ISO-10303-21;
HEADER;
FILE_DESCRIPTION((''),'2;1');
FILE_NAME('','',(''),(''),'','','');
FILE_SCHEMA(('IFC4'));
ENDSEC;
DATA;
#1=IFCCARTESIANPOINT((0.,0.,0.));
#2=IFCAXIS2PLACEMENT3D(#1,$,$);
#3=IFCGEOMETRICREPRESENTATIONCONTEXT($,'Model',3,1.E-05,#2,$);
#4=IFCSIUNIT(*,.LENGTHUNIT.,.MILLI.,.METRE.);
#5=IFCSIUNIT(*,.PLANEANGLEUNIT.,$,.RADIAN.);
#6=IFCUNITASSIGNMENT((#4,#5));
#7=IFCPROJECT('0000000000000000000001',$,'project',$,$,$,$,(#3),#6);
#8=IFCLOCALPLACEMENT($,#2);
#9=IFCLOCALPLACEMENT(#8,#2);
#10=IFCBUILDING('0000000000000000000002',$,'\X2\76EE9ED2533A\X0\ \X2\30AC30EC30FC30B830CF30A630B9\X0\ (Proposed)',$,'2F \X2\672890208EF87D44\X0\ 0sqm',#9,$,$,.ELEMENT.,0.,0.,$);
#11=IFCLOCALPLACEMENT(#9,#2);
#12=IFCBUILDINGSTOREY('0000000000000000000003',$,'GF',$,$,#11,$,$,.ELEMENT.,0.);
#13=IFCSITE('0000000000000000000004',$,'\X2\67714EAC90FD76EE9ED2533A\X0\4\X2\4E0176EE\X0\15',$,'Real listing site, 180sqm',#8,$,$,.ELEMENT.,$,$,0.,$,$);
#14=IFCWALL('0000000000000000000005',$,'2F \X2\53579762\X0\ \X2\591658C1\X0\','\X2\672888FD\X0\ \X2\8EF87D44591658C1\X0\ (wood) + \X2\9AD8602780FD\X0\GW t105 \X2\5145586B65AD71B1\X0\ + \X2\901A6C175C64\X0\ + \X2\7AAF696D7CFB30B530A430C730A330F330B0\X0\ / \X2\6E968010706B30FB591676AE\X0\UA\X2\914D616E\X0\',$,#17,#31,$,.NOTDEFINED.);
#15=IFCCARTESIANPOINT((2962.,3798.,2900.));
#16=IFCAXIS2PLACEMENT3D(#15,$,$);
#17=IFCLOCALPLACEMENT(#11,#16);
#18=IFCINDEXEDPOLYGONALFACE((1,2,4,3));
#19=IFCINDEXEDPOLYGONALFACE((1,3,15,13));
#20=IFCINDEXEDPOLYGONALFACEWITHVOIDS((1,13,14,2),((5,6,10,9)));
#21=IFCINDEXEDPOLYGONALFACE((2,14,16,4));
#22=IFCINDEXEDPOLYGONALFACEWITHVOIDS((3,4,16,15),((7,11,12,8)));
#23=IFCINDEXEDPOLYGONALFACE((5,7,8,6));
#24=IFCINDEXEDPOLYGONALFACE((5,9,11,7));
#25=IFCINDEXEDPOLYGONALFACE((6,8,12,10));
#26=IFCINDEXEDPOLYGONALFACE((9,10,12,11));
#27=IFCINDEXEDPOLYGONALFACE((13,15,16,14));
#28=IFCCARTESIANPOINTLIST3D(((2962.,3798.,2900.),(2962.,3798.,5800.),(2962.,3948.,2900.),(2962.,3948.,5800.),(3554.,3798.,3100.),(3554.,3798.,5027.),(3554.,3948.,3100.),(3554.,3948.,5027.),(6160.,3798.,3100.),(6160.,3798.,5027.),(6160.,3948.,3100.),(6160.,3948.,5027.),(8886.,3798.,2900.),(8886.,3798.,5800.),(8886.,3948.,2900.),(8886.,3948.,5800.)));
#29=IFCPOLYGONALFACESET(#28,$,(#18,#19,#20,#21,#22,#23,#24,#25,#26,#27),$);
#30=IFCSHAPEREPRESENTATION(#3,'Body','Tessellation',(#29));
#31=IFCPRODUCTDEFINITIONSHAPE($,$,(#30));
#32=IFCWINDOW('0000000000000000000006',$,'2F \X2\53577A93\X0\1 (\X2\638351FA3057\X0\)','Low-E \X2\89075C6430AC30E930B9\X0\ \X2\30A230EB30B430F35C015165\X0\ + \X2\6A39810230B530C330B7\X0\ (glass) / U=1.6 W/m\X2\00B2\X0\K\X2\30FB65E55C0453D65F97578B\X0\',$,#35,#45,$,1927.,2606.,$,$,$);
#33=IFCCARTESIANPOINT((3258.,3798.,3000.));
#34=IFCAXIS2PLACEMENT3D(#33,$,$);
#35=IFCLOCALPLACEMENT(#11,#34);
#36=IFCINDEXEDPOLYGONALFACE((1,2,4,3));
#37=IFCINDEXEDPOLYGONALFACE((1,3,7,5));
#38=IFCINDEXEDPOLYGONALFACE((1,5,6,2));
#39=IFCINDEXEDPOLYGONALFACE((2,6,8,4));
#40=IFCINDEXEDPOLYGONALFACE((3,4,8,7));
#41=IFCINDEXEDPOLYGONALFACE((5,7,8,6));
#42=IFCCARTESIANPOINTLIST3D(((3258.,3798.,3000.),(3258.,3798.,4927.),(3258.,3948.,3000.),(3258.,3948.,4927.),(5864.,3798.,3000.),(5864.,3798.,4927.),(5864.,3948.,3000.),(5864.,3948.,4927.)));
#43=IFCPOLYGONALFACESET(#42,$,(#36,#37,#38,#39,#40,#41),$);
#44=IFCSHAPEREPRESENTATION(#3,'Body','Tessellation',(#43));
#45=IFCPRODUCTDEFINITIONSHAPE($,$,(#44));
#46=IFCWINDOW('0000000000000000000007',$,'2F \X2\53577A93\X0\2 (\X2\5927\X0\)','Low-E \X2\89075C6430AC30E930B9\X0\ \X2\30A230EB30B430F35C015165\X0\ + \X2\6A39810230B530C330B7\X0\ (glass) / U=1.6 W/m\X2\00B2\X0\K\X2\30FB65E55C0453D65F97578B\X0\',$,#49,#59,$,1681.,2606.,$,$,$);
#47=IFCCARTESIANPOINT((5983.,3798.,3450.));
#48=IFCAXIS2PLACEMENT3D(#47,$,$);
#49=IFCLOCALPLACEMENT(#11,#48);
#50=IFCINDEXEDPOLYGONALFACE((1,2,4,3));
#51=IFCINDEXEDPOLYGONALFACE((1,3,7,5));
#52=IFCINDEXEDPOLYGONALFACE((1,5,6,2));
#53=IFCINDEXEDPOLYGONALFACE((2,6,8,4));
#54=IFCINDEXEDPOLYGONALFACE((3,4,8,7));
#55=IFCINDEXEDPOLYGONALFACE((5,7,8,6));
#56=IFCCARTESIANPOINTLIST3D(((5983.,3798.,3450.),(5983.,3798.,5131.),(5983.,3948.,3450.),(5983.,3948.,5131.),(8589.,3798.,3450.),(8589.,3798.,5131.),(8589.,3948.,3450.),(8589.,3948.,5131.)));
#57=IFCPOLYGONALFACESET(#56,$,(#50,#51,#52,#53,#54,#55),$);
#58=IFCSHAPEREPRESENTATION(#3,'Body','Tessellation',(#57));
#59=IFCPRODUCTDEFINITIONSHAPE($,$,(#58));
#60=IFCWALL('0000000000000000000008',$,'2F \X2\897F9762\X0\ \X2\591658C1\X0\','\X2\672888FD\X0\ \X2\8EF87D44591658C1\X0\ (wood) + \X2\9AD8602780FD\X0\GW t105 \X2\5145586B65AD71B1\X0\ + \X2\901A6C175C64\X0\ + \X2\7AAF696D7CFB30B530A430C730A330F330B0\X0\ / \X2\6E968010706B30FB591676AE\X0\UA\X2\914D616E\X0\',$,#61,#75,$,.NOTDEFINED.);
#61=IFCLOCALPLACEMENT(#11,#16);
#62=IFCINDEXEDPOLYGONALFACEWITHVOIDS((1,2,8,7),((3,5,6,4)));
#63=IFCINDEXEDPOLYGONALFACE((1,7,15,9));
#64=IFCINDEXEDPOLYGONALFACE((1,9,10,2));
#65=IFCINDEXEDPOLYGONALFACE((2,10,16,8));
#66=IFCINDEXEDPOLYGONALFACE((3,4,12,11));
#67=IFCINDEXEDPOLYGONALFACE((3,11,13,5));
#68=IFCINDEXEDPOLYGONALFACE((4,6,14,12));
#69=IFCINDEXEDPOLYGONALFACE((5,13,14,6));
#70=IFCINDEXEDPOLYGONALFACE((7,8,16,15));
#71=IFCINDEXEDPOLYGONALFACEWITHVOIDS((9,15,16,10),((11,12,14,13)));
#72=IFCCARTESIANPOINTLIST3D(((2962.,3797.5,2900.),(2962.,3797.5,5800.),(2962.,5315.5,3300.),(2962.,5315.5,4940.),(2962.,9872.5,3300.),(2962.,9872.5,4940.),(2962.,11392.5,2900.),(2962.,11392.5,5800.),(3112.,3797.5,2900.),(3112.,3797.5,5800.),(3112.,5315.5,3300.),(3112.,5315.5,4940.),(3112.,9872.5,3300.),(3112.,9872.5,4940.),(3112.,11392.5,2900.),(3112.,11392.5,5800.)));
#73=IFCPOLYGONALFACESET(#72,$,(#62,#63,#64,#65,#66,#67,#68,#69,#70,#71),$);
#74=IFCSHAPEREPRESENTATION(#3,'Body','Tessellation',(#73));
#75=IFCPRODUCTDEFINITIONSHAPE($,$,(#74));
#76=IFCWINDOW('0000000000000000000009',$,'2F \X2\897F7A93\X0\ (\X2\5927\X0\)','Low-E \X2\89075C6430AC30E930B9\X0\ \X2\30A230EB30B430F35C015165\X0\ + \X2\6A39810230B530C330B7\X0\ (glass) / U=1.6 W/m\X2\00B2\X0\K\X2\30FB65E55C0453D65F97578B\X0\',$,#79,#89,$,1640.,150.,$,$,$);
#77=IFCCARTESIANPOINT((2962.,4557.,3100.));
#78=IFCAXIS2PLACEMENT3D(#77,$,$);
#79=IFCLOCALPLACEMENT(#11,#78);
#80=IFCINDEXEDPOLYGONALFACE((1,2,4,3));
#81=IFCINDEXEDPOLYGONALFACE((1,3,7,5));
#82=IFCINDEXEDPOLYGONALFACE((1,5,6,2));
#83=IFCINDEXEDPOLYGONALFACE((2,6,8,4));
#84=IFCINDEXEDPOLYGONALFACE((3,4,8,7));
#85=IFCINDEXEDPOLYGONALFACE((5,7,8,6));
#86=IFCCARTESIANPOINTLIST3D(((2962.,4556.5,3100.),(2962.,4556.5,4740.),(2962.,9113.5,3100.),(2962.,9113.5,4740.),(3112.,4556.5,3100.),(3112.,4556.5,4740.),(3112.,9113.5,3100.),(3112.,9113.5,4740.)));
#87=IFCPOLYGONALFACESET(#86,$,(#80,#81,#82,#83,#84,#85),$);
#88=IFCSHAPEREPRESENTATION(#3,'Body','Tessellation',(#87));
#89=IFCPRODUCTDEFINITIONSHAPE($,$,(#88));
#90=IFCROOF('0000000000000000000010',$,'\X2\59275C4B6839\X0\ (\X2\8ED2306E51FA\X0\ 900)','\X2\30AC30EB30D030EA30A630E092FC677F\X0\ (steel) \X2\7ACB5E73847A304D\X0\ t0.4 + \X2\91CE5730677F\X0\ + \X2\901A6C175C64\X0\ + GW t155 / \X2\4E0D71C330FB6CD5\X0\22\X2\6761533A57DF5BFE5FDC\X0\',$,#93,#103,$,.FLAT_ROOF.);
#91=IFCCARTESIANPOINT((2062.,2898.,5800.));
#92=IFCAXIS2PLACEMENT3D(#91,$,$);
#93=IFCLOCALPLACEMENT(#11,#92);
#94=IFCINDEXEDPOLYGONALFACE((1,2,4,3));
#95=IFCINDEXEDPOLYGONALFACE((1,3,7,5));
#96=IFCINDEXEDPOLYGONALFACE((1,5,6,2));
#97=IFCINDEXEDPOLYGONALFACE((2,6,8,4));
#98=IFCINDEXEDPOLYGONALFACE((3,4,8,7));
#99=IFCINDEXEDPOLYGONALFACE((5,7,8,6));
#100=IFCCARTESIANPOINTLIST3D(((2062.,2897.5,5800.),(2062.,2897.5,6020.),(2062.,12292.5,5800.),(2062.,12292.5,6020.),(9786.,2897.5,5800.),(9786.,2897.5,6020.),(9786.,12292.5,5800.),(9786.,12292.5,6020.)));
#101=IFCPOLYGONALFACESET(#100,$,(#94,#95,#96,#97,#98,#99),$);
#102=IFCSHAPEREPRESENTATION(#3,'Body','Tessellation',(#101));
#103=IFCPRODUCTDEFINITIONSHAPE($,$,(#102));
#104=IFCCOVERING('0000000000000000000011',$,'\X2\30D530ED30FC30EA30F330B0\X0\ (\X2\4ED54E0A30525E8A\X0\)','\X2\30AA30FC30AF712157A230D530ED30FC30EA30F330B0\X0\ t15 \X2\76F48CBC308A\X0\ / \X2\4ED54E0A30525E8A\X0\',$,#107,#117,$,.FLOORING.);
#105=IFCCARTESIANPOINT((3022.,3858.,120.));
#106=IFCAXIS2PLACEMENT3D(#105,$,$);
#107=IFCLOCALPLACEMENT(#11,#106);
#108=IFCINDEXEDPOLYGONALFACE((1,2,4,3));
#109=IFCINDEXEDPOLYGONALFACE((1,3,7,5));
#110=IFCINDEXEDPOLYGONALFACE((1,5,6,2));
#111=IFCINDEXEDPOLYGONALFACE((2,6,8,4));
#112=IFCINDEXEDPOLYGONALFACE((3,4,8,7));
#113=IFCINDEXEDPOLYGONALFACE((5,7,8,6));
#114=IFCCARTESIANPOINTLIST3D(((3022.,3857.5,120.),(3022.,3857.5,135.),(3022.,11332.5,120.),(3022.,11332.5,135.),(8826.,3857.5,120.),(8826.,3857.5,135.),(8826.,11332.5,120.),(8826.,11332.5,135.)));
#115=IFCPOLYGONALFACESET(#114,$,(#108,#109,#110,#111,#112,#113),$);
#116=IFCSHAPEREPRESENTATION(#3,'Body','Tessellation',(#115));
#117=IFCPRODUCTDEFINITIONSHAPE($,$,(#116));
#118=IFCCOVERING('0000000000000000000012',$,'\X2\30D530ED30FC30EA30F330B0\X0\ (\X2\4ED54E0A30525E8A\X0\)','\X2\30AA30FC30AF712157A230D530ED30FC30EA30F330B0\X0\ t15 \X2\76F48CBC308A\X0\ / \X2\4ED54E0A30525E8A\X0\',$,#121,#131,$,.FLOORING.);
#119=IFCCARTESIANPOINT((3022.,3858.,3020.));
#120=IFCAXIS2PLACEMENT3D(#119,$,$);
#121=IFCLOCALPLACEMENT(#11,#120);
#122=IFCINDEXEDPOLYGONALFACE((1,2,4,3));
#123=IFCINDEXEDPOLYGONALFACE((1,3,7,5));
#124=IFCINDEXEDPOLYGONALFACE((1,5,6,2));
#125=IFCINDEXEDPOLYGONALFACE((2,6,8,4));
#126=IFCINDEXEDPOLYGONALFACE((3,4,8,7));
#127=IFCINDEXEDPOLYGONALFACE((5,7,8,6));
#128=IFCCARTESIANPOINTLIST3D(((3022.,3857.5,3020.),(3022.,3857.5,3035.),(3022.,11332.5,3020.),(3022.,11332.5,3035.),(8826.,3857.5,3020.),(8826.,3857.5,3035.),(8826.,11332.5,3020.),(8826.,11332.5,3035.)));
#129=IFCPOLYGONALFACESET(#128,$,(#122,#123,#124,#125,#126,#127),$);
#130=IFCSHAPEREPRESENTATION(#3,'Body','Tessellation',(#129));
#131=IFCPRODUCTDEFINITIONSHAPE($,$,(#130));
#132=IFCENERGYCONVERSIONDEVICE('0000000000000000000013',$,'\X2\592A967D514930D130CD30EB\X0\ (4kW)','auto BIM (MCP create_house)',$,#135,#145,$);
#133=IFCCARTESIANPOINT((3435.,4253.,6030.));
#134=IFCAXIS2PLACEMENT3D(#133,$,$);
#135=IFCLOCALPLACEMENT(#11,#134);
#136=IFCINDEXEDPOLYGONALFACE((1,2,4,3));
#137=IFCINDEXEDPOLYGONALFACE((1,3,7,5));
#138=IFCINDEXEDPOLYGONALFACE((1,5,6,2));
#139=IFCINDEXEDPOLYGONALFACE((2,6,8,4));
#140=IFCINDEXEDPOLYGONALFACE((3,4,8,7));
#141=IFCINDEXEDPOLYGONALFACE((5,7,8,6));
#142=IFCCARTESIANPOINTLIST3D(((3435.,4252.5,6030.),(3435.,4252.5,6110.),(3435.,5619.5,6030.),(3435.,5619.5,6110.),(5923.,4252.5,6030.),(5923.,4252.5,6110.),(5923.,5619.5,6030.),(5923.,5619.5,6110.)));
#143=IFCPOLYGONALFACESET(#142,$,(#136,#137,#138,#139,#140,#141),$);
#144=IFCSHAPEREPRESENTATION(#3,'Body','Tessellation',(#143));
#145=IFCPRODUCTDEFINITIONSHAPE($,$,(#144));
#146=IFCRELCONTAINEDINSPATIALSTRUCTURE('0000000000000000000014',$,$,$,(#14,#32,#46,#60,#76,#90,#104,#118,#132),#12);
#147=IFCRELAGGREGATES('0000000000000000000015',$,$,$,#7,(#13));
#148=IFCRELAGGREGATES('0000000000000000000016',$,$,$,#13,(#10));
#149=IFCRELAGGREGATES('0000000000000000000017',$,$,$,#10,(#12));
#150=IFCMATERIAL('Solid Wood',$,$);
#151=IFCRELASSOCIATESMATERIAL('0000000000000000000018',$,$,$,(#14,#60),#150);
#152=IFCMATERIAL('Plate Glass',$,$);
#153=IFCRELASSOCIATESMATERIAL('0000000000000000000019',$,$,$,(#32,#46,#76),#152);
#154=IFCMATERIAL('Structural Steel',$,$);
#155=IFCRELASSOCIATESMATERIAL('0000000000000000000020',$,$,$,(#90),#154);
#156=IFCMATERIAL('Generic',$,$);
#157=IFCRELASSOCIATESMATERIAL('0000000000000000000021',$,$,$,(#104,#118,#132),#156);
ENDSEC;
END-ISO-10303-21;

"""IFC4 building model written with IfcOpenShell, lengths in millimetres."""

from ifc_helpers import new_model, si_unit, frame, frame_2d, origin, place, context, project, spatial, rectangle, extrude, material, element, fill, save


model = new_model("IFC4")

# Units and contexts
model_context = context("Model", 3, precision=1e-05, world=origin())
ifc_project = project(units=[si_unit("LENGTHUNIT", "METRE", prefix="MILLI"), si_unit("PLANEANGLEUNIT", "RADIAN")], contexts=[model_context])

# Site, building, storey
site_placement = place(None, origin())
site = spatial("IfcSite", under=ifc_project, at=site_placement, Name="東京都目黒区4丁目15", ObjectType="Real listing site, 180sqm", CompositionType="ELEMENT", RefElevation=0.0)
building_placement = place(site_placement, origin())
building = spatial("IfcBuilding", under=site, at=building_placement, Name="目黒区 ガレージハウス (Proposed)", ObjectType="2F 木造軸組 0sqm", CompositionType="ELEMENT", ElevationOfRefHeight=0.0, ElevationOfTerrain=0.0)
storey_placement = place(building_placement, origin())
storey = spatial("IfcBuildingStorey", under=building, at=storey_placement, Name="GF", CompositionType="ELEMENT", Elevation=0.0)

# Shared definitions
ifc_material_1 = material(Name="Solid Wood")

# Shared definitions
ifc_material_2 = material(Name="Plate Glass")

# Wall, openings, windows
wall_1_placement = place(storey_placement, frame((2962.0, 3798.0, 2900.0)))
wall_1 = element("IfcWall", 1, at=wall_1_placement, inside=storey, material=ifc_material_1, Name="2F 南面 外壁", Description="木製 軸組外壁 (wood) + 高性能GW t105 充填断熱 + 通気層 + 窯業系サイディング / 準耐火・外皮UA配慮", PredefinedType="NOTDEFINED", context=model_context, shape_type="SweptSolid", body=[
    extrude(rectangle(XDim=5924.0, YDim=150.0, at=frame_2d((2962.0, 75.0))), frame((2962.0, 3798.0, 2900.0)), (0.0, 0.0, 1.0), 2900.0),
])
opening_1_placement = place(storey_placement, frame((3258.0, 3798.0, 3000.0)))
opening_1 = element("IfcOpeningElement", 2, at=opening_1_placement, cuts=wall_1, PredefinedType="NOTDEFINED", context=model_context, shape_type="SweptSolid", body=[
    extrude(rectangle(XDim=2606.0, YDim=150.0, at=frame_2d((1303.0, 75.0))), frame((3258.0, 3798.0, 3000.0)), (0.0, 0.0, 1.0), 1927.0),
])
opening_2_placement = place(storey_placement, frame((5983.0, 3798.0, 3450.0)))
opening_2 = element("IfcOpeningElement", 3, at=opening_2_placement, cuts=wall_1, PredefinedType="NOTDEFINED", context=model_context, shape_type="SweptSolid", body=[
    extrude(rectangle(XDim=2606.0, YDim=150.0, at=frame_2d((1303.0, 75.0))), frame((5983.0, 3798.0, 3450.0)), (0.0, 0.0, 1.0), 1681.0),
])
window_1_placement = place(storey_placement, frame((3258.0, 3798.0, 3000.0)))
window_1 = element("IfcWindow", 4, at=window_1_placement, inside=storey, material=ifc_material_2, Name="2F 南窓1 (掃出し)", Description="Low-E 複層ガラス アルゴン封入 + 樹脂サッシ (glass) / U=1.6 W/m²K・日射取得型", OverallHeight=1927.0, OverallWidth=2606.0, context=model_context, shape_type="SweptSolid", body=[
    extrude(rectangle(XDim=2606.0, YDim=150.0, at=frame_2d((1303.0, 75.0))), frame((3258.0, 3798.0, 3000.0)), (0.0, 0.0, 1.0), 1927.0),
])
fill(opening_1, window_1)
window_2_placement = place(storey_placement, frame((5983.0, 3798.0, 3450.0)))
window_2 = element("IfcWindow", 5, at=window_2_placement, inside=storey, material=ifc_material_2, Name="2F 南窓2 (大)", Description="Low-E 複層ガラス アルゴン封入 + 樹脂サッシ (glass) / U=1.6 W/m²K・日射取得型", OverallHeight=1681.0, OverallWidth=2606.0, context=model_context, shape_type="SweptSolid", body=[
    extrude(rectangle(XDim=2606.0, YDim=150.0, at=frame_2d((1303.0, 75.0))), frame((5983.0, 3798.0, 3450.0)), (0.0, 0.0, 1.0), 1681.0),
])
fill(opening_2, window_2)

# Wall, opening, window
wall_2_placement = place(storey_placement, frame((2962.0, 3798.0, 2900.0)))
wall_2 = element("IfcWall", 6, at=wall_2_placement, inside=storey, material=ifc_material_1, Name="2F 西面 外壁", Description="木製 軸組外壁 (wood) + 高性能GW t105 充填断熱 + 通気層 + 窯業系サイディング / 準耐火・外皮UA配慮", PredefinedType="NOTDEFINED", context=model_context, shape_type="SweptSolid", body=[
    extrude(rectangle(XDim=150.0, YDim=7595.0, at=frame_2d((75.0, 3797.0))), frame((2962.0, 3798.0, 2900.0)), (0.0, 0.0, 1.0), 2900.0),
])
opening_3_placement = place(storey_placement, frame((2962.0, 4557.0, 3100.0)))
opening_3 = element("IfcOpeningElement", 7, at=opening_3_placement, cuts=wall_2, PredefinedType="NOTDEFINED", context=model_context, shape_type="SweptSolid", body=[
    extrude(rectangle(XDim=150.0, YDim=4557.0, at=frame_2d((75.0, 2278.0))), frame((2962.0, 4557.0, 3100.0)), (0.0, 0.0, 1.0), 1640.0),
])
window_3_placement = place(storey_placement, frame((2962.0, 4557.0, 3100.0)))
window_3 = element("IfcWindow", 8, at=window_3_placement, inside=storey, material=ifc_material_2, Name="2F 西窓 (大)", Description="Low-E 複層ガラス アルゴン封入 + 樹脂サッシ (glass) / U=1.6 W/m²K・日射取得型", OverallHeight=1640.0, OverallWidth=150.0, context=model_context, shape_type="SweptSolid", body=[
    extrude(rectangle(XDim=150.0, YDim=4557.0, at=frame_2d((75.0, 2278.0))), frame((2962.0, 4557.0, 3100.0)), (0.0, 0.0, 1.0), 1640.0),
])
fill(opening_3, window_3)

# Roof
ifc_material_3 = material(Name="Structural Steel")
roof_placement = place(storey_placement, frame((2062.0, 2898.0, 5800.0)))
element("IfcRoof", 9, at=roof_placement, inside=storey, material=ifc_material_3, Name="大屋根 (軒の出 900)", Description="ガルバリウム鋼板 (steel) 立平葺き t0.4 + 野地板 + 通気層 + GW t155 / 不燃・法22条区域対応", PredefinedType="FLAT_ROOF", context=model_context, shape_type="SweptSolid", body=[
    extrude(rectangle(XDim=7724.0, YDim=9395.0, at=frame_2d((3862.0, 4697.0))), frame((2062.0, 2898.0, 5800.0)), (0.0, 0.0, 1.0), 220.0),
])

# Coverings
ifc_material_4 = material(Name="Generic")
covering_1_placement = place(storey_placement, frame((3022.0, 3858.0, 120.0)))
element("IfcCovering", 10, at=covering_1_placement, inside=storey, material=ifc_material_4, Name="フローリング (仕上げ床)", Description="オーク無垢フローリング t15 直貼り / 仕上げ床", PredefinedType="FLOORING", context=model_context, shape_type="SweptSolid", body=[
    extrude(rectangle(XDim=5804.0, YDim=7475.0, at=frame_2d((2902.0, 3737.0))), frame((3022.0, 3858.0, 120.0)), (0.0, 0.0, 1.0), 15.0),
])
covering_2_placement = place(storey_placement, frame((3022.0, 3858.0, 3020.0)))
element("IfcCovering", 11, at=covering_2_placement, inside=storey, material=ifc_material_4, Name="フローリング (仕上げ床)", Description="オーク無垢フローリング t15 直貼り / 仕上げ床", PredefinedType="FLOORING", context=model_context, shape_type="SweptSolid", body=[
    extrude(rectangle(XDim=5804.0, YDim=7475.0, at=frame_2d((2902.0, 3737.0))), frame((3022.0, 3858.0, 3020.0)), (0.0, 0.0, 1.0), 15.0),
])

# Energy conversion device
energy_conversion_device_placement = place(storey_placement, frame((3435.0, 4253.0, 6030.0)))
element("IfcEnergyConversionDevice", 12, at=energy_conversion_device_placement, inside=storey, material=ifc_material_4, Name="太陽光パネル (4kW)", Description="auto BIM (MCP create_house)", context=model_context, shape_type="SweptSolid", body=[
    extrude(rectangle(XDim=2488.0, YDim=1367.0, at=frame_2d((1244.0, 683.0))), frame((3435.0, 4253.0, 6030.0)), (0.0, 0.0, 1.0), 80.0),
])

save(model, "model.ifc")
